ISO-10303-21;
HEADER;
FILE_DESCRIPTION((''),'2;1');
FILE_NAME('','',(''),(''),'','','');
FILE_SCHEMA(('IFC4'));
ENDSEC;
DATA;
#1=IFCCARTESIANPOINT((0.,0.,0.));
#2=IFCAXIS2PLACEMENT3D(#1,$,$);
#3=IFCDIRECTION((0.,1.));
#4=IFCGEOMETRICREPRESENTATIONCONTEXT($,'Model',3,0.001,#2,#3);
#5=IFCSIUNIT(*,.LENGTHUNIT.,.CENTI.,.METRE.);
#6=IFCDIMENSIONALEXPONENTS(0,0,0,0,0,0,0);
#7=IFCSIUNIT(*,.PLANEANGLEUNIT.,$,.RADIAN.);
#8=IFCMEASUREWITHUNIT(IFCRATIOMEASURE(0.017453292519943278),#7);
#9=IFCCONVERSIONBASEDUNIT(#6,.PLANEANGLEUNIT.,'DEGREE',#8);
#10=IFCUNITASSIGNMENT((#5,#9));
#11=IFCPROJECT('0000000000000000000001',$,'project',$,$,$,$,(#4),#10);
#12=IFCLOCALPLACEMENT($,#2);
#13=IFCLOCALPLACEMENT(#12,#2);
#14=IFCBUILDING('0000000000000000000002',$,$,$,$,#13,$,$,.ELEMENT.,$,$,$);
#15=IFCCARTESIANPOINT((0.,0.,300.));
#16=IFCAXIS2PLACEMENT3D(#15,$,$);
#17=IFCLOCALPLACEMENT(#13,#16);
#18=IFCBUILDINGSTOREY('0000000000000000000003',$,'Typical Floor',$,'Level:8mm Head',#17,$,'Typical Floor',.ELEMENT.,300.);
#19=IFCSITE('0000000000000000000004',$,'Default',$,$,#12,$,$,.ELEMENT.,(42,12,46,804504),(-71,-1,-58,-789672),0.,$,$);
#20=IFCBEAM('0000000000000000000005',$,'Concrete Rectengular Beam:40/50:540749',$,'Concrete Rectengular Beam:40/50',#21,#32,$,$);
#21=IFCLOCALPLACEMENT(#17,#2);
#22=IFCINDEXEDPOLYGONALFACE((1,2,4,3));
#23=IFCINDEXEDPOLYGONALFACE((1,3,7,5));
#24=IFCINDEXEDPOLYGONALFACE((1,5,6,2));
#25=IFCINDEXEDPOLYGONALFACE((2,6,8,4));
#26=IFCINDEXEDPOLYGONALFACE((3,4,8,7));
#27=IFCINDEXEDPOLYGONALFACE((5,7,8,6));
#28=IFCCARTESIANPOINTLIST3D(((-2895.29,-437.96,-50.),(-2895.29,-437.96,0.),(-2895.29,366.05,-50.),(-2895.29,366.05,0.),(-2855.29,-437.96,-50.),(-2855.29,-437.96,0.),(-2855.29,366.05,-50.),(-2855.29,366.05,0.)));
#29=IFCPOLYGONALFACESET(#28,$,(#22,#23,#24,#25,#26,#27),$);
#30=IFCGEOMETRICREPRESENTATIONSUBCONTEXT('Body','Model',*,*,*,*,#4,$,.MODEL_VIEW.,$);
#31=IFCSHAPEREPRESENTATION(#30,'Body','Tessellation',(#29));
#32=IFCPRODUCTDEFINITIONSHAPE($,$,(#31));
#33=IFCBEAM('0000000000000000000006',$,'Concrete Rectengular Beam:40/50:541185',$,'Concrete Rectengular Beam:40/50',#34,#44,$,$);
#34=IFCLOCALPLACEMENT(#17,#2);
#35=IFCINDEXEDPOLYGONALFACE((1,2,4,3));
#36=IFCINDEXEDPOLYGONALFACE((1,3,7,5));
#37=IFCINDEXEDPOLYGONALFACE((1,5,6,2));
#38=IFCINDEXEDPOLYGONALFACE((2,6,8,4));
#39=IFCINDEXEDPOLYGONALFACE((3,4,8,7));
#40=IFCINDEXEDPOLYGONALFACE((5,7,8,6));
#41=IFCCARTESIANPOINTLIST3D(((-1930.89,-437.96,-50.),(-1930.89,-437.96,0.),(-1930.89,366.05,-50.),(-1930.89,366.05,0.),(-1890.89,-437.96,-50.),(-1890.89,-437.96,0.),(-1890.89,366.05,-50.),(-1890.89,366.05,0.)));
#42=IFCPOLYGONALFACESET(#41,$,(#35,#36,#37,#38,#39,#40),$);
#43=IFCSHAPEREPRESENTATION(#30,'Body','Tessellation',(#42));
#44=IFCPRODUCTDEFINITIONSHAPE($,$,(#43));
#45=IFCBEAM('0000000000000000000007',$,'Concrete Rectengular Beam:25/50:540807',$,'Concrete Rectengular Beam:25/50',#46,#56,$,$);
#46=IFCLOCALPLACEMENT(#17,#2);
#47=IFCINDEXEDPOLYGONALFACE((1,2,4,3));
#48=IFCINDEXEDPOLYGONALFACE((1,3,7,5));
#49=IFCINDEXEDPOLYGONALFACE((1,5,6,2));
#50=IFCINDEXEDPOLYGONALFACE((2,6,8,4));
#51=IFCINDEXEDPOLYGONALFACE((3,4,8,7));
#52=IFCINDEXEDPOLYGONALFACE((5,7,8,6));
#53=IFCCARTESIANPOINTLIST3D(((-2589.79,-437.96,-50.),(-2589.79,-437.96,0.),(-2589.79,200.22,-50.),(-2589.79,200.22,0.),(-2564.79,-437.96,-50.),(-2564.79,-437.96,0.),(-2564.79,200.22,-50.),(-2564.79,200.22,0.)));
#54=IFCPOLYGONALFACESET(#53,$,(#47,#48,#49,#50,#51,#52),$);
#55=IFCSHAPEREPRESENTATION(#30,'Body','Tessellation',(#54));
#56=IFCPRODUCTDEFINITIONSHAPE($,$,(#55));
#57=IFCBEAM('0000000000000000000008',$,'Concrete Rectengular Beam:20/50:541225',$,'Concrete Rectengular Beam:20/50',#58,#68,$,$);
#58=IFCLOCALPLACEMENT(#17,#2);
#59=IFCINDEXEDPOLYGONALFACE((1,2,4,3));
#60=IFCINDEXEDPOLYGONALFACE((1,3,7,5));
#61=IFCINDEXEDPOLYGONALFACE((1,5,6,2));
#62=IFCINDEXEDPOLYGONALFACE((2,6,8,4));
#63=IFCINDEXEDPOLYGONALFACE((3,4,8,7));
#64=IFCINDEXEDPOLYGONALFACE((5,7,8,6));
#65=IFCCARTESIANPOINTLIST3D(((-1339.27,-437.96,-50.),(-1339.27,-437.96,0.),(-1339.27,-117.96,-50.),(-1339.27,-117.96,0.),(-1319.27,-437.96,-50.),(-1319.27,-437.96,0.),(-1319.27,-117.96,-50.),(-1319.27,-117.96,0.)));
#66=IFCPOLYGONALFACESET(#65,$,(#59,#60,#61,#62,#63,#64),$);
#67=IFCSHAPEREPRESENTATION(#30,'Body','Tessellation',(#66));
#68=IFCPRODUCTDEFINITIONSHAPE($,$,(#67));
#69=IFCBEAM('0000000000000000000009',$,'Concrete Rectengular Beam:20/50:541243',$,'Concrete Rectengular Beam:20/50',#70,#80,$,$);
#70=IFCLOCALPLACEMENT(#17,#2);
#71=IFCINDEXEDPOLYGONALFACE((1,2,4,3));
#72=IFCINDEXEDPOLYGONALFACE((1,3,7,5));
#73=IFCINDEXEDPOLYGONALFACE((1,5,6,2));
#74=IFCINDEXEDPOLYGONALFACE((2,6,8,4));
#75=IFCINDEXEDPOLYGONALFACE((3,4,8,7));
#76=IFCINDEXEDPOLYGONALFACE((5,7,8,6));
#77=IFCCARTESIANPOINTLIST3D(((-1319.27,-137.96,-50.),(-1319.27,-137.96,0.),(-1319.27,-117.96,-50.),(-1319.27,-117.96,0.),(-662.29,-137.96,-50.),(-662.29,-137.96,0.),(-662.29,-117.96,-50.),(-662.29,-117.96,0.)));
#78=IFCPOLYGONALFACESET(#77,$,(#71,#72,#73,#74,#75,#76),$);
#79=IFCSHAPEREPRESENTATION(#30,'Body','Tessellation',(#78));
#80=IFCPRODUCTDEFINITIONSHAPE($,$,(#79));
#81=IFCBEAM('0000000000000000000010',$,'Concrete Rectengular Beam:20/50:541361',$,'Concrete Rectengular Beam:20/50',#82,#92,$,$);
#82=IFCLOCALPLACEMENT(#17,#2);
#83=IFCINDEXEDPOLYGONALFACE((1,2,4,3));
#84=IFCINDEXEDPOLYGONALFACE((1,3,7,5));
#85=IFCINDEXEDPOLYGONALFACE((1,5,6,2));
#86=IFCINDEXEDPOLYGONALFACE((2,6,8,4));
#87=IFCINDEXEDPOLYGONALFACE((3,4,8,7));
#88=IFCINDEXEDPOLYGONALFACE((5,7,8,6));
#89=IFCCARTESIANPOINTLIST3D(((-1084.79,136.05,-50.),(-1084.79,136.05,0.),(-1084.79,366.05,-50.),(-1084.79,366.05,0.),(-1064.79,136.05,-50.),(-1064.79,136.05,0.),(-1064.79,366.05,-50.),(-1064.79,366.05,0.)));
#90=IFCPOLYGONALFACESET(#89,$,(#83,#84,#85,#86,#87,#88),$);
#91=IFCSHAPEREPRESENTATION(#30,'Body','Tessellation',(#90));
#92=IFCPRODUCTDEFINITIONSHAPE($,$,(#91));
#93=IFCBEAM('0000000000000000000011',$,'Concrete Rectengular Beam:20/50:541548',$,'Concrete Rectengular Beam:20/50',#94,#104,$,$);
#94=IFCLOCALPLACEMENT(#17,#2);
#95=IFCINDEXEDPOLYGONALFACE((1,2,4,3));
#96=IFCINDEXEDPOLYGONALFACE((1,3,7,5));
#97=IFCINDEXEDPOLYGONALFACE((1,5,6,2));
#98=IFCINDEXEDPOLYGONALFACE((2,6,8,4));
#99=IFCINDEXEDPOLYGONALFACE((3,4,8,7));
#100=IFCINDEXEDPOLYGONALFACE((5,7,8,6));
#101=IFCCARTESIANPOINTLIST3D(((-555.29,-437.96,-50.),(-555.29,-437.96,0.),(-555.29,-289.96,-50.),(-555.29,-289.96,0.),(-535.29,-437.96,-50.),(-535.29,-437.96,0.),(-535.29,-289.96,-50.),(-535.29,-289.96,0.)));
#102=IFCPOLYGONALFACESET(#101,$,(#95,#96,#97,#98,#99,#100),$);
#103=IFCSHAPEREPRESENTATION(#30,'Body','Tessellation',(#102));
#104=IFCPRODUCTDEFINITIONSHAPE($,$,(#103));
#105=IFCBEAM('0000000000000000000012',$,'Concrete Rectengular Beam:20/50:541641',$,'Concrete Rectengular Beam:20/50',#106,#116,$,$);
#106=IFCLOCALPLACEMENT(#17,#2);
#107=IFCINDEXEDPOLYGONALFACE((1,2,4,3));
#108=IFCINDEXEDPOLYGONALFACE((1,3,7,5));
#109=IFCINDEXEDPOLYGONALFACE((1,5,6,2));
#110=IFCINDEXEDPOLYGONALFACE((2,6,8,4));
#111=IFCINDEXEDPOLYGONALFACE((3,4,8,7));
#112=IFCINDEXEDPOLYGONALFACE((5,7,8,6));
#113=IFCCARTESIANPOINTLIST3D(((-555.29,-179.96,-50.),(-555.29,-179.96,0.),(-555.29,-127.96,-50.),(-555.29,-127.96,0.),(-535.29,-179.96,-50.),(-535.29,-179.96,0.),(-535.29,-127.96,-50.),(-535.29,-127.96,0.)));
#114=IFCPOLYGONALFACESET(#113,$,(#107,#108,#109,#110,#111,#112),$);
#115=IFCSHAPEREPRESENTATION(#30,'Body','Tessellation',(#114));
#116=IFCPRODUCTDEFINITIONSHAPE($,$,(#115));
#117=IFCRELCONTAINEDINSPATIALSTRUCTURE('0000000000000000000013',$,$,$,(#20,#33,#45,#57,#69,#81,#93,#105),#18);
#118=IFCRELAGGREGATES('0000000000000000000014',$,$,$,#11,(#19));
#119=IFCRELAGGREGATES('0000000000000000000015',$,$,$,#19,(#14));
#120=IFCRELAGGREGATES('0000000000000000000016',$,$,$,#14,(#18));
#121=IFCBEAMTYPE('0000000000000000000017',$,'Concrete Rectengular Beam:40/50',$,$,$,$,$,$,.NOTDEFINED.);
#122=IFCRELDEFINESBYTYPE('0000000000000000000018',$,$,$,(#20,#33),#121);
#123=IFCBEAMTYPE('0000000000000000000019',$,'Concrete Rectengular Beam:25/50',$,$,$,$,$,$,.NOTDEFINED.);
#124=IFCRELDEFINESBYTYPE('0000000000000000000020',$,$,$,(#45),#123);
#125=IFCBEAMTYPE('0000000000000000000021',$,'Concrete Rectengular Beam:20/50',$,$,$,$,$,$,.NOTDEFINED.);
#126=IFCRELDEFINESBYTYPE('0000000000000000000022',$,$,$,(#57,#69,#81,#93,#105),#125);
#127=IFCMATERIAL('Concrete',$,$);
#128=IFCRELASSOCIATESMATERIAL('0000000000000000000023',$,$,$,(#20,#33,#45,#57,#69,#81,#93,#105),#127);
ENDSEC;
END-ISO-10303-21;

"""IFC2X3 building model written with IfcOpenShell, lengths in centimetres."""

from ifc_helpers import new_model, entity, si_unit, converted_unit, direction, frame, frame_2d, origin, origin_2d_with_axis, place, context, subcontext, project, spatial, rectangle, extrude, material, type_object, element, save


model = new_model("IFC2X3")

# Units and contexts
model_context = context("Model", 3, precision=0.001, world=origin(), true_north=direction((0.0, 1.0)))
body_context = subcontext(model_context, "Body", "Model", "MODEL_VIEW")
ifc_project = project(units=[si_unit("LENGTHUNIT", "METRE", prefix="CENTI"), converted_unit("PLANEANGLEUNIT", "DEGREE", entity("IfcRatioMeasure", 0.017453292519943278), si_unit("PLANEANGLEUNIT", "RADIAN"), dimensions=[0, 0, 0, 0, 0, 0, 0])], contexts=[model_context])

# Site, building, storey
site_placement = place(None, origin())
site = spatial("IfcSite", under=ifc_project, at=site_placement, Name="Default", CompositionType="ELEMENT", RefLatitude=(42, 12, 46, 804504), RefLongitude=(-71, -1, -58, -789672), RefElevation=0.0)
building_placement = place(site_placement, origin())
building = spatial("IfcBuilding", under=site, at=building_placement, CompositionType="ELEMENT")
storey_placement = place(building_placement, frame((0.0, 0.0, 300.0)))
storey = spatial("IfcBuildingStorey", under=building, at=storey_placement, Name="Typical Floor", ObjectType="Level:8mm Head", LongName="Typical Floor", CompositionType="ELEMENT", Elevation=300.0)

# Beams
ifc_material = material(Name="Concrete")
beam_type_1 = type_object("IfcBeamType", Name="Concrete Rectengular Beam:40/50", PredefinedType="NOTDEFINED")
beam_1_placement = place(storey_placement, frame((-2875.29, -457.96, 0.0), z_axis=(0.0, 0.0, 1.0), x_axis=(0.0, 1.0, 0.0)))
element("IfcBeam", 1, at=beam_1_placement, inside=storey, type_object=beam_type_1, material=ifc_material, Name="Concrete Rectengular Beam:40/50:540749", ObjectType="Concrete Rectengular Beam:40/50", context=body_context, shape_type="SweptSolid", body=[
    extrude(rectangle(XDim=50.0, YDim=40.0, at=origin_2d_with_axis()), frame((20.0, 0.0, -25.0), z_axis=(1.0, 0.0, 0.0), x_axis=(0.0, 0.0, -1.0)), (0.0, 0.0, 1.0), 804.0),
])
beam_2_placement = place(storey_placement, frame((-1910.89, -457.96, 0.0), z_axis=(0.0, 0.0, 1.0), x_axis=(0.0, 1.0, 0.0)))
element("IfcBeam", 2, at=beam_2_placement, inside=storey, type_object=beam_type_1, material=ifc_material, Name="Concrete Rectengular Beam:40/50:541185", ObjectType="Concrete Rectengular Beam:40/50", context=body_context, shape_type="SweptSolid", body=[
    extrude(rectangle(XDim=50.0, YDim=40.0, at=origin_2d_with_axis()), frame((20.0, 0.0, -25.0), z_axis=(1.0, 0.0, 0.0), x_axis=(0.0, 0.0, -1.0)), (0.0, 0.0, 1.0), 804.0),
])
beam_type_2 = type_object("IfcBeamType", Name="Concrete Rectengular Beam:25/50", PredefinedType="NOTDEFINED")
beam_3_placement = place(storey_placement, frame((-2577.29, 212.72, 0.0), z_axis=(0.0, 0.0, 1.0), x_axis=(0.0, -1.0, 0.0)))
element("IfcBeam", 3, at=beam_3_placement, inside=storey, type_object=beam_type_2, material=ifc_material, Name="Concrete Rectengular Beam:25/50:540807", ObjectType="Concrete Rectengular Beam:25/50", context=body_context, shape_type="SweptSolid", body=[
    extrude(rectangle(XDim=50.0, YDim=25.0, at=origin_2d_with_axis()), frame((12.5, 0.0, -25.0), z_axis=(1.0, 0.0, 0.0), x_axis=(0.0, 0.0, -1.0)), (0.0, 0.0, 1.0), 638.18),
])
beam_type_3 = type_object("IfcBeamType", Name="Concrete Rectengular Beam:20/50", PredefinedType="NOTDEFINED")
beam_4_placement = place(storey_placement, frame((-1329.27, -457.96, 0.0), z_axis=(0.0, 0.0, 1.0), x_axis=(0.0, 1.0, 0.0)))
element("IfcBeam", 4, at=beam_4_placement, inside=storey, type_object=beam_type_3, material=ifc_material, Name="Concrete Rectengular Beam:20/50:541225", ObjectType="Concrete Rectengular Beam:20/50", context=body_context, shape_type="SweptSolid", body=[
    extrude(rectangle(XDim=50.0, YDim=20.0, at=frame_2d((0.0, 0.0), x_axis=(1.0, 0.0))), frame((20.0, 0.0, -25.0), z_axis=(1.0, 0.0, 0.0), x_axis=(0.0, 0.0, -1.0)), (0.0, 0.0, 1.0), 320.0),
])
beam_5_placement = place(storey_placement, frame((-1329.27, -127.96, 0.0)))
element("IfcBeam", 5, at=beam_5_placement, inside=storey, type_object=beam_type_3, material=ifc_material, Name="Concrete Rectengular Beam:20/50:541243", ObjectType="Concrete Rectengular Beam:20/50", context=body_context, shape_type="SweptSolid", body=[
    extrude(rectangle(XDim=50.0, YDim=20.0, at=frame_2d((0.0, 0.0), x_axis=(1.0, 0.0))), frame((10.0, 0.0, -25.0), z_axis=(1.0, 0.0, 0.0), x_axis=(0.0, 0.0, -1.0)), (0.0, 0.0, 1.0), 656.98),
])
beam_6_placement = place(storey_placement, frame((-1074.79, 126.05, 0.0), z_axis=(0.0, 0.0, 1.0), x_axis=(0.0, 1.0, 0.0)))
element("IfcBeam", 6, at=beam_6_placement, inside=storey, type_object=beam_type_3, material=ifc_material, Name="Concrete Rectengular Beam:20/50:541361", ObjectType="Concrete Rectengular Beam:20/50", context=body_context, shape_type="SweptSolid", body=[
    extrude(rectangle(XDim=50.0, YDim=20.0, at=frame_2d((0.0, 0.0), x_axis=(1.0, 0.0))), frame((10.0, 0.0, -25.0), z_axis=(1.0, 0.0, 0.0), x_axis=(0.0, 0.0, -1.0)), (0.0, 0.0, 1.0), 230.0),
])
beam_7_placement = place(storey_placement, frame((-545.29, -457.96, 0.0), z_axis=(0.0, 0.0, 1.0), x_axis=(0.0, 1.0, 0.0)))
element("IfcBeam", 7, at=beam_7_placement, inside=storey, type_object=beam_type_3, material=ifc_material, Name="Concrete Rectengular Beam:20/50:541548", ObjectType="Concrete Rectengular Beam:20/50", context=body_context, shape_type="SweptSolid", body=[
    extrude(rectangle(XDim=50.0, YDim=20.0, at=frame_2d((0.0, 0.0), x_axis=(1.0, 0.0))), frame((20.0, 0.0, -25.0), z_axis=(1.0, 0.0, 0.0), x_axis=(0.0, 0.0, -1.0)), (0.0, 0.0, 1.0), 148.0),
])
beam_8_placement = place(storey_placement, frame((-545.29, -117.96, 0.0), z_axis=(0.0, 0.0, 1.0), x_axis=(0.0, -1.0, 0.0)))
element("IfcBeam", 8, at=beam_8_placement, inside=storey, type_object=beam_type_3, material=ifc_material, Name="Concrete Rectengular Beam:20/50:541641", ObjectType="Concrete Rectengular Beam:20/50", context=body_context, shape_type="SweptSolid", body=[
    extrude(rectangle(XDim=50.0, YDim=20.0, at=frame_2d((0.0, 0.0), x_axis=(1.0, 0.0))), frame((10.0, 0.0, -25.0), z_axis=(1.0, 0.0, 0.0), x_axis=(0.0, 0.0, -1.0)), (0.0, 0.0, 1.0), 52.0),
])

save(model, "model.ifc")
